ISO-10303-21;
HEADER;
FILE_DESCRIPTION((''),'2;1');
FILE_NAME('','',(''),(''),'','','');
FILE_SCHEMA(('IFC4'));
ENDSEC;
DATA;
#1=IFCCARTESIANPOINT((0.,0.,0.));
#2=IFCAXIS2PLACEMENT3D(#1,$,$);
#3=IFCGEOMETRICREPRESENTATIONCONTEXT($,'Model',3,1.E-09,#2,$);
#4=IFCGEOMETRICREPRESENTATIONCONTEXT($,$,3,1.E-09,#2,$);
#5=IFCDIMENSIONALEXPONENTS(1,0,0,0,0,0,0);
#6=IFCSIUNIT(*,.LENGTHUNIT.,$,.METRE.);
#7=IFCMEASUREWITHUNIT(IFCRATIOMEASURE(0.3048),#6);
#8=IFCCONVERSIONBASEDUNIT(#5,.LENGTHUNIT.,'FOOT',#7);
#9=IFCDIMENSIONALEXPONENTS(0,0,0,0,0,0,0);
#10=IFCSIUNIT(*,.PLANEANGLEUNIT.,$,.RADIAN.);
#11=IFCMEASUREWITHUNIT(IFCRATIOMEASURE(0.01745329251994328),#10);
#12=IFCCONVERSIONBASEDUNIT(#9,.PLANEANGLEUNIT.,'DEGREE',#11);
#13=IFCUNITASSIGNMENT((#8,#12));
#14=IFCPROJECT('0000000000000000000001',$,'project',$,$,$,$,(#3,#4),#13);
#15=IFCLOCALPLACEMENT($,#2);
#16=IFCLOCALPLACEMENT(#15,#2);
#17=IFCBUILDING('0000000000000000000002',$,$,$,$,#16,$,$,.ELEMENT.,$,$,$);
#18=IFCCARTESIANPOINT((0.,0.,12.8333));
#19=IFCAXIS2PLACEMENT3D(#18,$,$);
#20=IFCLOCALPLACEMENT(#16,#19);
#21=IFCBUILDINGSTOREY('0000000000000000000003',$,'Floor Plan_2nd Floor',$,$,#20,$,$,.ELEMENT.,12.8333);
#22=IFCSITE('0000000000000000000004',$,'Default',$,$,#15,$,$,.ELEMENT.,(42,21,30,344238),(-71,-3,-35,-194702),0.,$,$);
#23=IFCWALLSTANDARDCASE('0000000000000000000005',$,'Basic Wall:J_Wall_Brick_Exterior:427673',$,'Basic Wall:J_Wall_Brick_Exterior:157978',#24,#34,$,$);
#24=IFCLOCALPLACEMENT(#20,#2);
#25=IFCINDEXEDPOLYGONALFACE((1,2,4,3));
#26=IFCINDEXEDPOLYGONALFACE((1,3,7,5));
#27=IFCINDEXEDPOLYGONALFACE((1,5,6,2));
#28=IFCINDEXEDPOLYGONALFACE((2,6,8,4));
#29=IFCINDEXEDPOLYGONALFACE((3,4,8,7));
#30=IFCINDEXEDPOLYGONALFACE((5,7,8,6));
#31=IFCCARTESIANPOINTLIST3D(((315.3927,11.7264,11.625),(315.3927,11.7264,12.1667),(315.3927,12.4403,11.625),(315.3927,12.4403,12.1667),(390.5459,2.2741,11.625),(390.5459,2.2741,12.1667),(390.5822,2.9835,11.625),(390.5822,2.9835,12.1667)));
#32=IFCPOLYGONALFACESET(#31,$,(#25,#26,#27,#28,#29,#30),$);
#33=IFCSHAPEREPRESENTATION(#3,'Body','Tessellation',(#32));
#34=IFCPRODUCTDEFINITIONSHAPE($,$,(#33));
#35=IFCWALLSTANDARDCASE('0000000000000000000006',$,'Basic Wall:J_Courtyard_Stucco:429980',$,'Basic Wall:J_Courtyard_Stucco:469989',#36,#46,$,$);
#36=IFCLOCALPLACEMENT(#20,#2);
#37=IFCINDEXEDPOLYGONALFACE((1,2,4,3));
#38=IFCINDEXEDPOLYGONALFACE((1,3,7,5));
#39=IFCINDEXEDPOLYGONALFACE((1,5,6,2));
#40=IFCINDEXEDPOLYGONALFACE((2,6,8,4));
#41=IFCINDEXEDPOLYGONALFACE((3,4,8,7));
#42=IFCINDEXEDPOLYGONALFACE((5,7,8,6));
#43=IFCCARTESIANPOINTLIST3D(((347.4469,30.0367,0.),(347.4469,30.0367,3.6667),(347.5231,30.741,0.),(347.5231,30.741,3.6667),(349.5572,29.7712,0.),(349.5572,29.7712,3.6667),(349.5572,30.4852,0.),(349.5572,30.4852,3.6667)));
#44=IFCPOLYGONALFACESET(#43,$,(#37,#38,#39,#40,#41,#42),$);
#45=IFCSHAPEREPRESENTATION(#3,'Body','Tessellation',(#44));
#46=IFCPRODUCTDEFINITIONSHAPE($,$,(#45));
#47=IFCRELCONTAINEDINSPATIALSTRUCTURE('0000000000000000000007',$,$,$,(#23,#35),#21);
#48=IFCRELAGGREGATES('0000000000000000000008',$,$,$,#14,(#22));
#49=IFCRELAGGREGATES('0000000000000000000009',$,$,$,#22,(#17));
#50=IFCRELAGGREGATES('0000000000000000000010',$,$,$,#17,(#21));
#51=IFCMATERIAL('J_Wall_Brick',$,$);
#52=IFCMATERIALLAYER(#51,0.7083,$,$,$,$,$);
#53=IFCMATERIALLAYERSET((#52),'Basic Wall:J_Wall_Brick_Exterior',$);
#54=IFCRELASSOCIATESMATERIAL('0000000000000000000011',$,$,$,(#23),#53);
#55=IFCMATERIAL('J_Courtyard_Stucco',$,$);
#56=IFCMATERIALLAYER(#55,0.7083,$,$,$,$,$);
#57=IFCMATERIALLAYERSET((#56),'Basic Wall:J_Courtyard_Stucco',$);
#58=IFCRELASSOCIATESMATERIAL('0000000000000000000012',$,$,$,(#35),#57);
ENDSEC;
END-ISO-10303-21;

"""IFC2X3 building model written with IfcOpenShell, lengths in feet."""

from ifc_helpers import new_model, entity, si_unit, converted_unit, frame, origin, place, context, project, spatial, polyline, outline, extrude, clip, halfspace, material, layer, layer_set, layer_usage, element, save


model = new_model("IFC2X3")

# Units and contexts
model_context = context("Model", 3, precision=1e-09, world=origin())
context_of_model = context(None, 3, precision=1e-09, world=origin())
ifc_project = project(units=[converted_unit("LENGTHUNIT", "FOOT", entity("IfcRatioMeasure", 0.3048), si_unit("LENGTHUNIT", "METRE"), dimensions=[1, 0, 0, 0, 0, 0, 0]), converted_unit("PLANEANGLEUNIT", "DEGREE", entity("IfcRatioMeasure", 0.01745329251994328), si_unit("PLANEANGLEUNIT", "RADIAN"), dimensions=[0, 0, 0, 0, 0, 0, 0])], contexts=[model_context, context_of_model])

# Site, building, storey
site_placement = place(None, origin())
site = spatial("IfcSite", under=ifc_project, at=site_placement, Name="Default", CompositionType="ELEMENT", RefLatitude=(42, 21, 30, 344238), RefLongitude=(-71, -3, -35, -194702), RefElevation=0.0)
building_placement = place(site_placement, origin())
building = spatial("IfcBuilding", under=site, at=building_placement, CompositionType="ELEMENT")
storey_placement = place(building_placement, frame((0.0, 0.0, 12.8333)))
storey = spatial("IfcBuildingStorey", under=building, at=storey_placement, Name="Floor Plan_2nd Floor", CompositionType="ELEMENT", Elevation=12.8333)

# Shared definitions
ifc_material_1 = material(Name="J_Wall_Brick")
ifc_layer_1 = layer(ifc_material_1, 0.7083)
ifc_layer_set_1 = layer_set([ifc_layer_1], Name="Basic Wall:J_Wall_Brick_Exterior")

# Walls
ifc_layer_usage_1 = layer_usage(ifc_layer_set_1, "AXIS2", "NEGATIVE", 0.3542)
wall_1_placement = place(storey_placement, frame((315.3485, 12.0889, 11.625), z_axis=(0.0, 0.0, 1.0), x_axis=(0.992183, -0.12479, 0.0)))
element("IfcWallStandardCase", 1, at=wall_1_placement, inside=storey, material=ifc_layer_usage_1, Name="Basic Wall:J_Wall_Brick_Exterior:427673", ObjectType="Basic Wall:J_Wall_Brick_Exterior:157978", context=model_context, shape_type="Clipping", body=[
    clip(extrude(outline(polyline([(75.8344, -0.3542), (75.7819, 0.3542), (74.9463, 0.3542), (0.0, 0.3542), (0.0891, -0.3542), (74.9987, -0.3542), (75.8344, -0.3542)])), origin(), (0.0, 0.0, 1.0), 0.5417), halfspace(origin(), True)),
])
ifc_material_2 = material(Name="J_Courtyard_Stucco")
ifc_layer_2 = layer(ifc_material_2, 0.7083)
ifc_layer_set_2 = layer_set([ifc_layer_2], Name="Basic Wall:J_Courtyard_Stucco")
ifc_layer_usage_2 = layer_usage(ifc_layer_set_2, "AXIS2", "NEGATIVE", 0.3542)
wall_2_placement = place(storey_placement, frame((347.4789, 30.3896, 0.0), z_axis=(0.0, 0.0, 1.0), x_axis=(0.992183, -0.12479, 0.0)))
element("IfcWallStandardCase", 2, at=wall_2_placement, inside=storey, material=ifc_layer_usage_2, Name="Basic Wall:J_Courtyard_Stucco:429980", ObjectType="Basic Wall:J_Courtyard_Stucco:469989", context=model_context, shape_type="Clipping", body=[
    clip(extrude(outline(polyline([(2.1392, -0.3542), (2.0501, 0.3542), (0.0, 0.3542), (0.0123, -0.3542), (2.1392, -0.3542)])), origin(), (0.0, 0.0, 1.0), 3.6667), halfspace(frame((0.0, 0.0, -12.6667)), True)),
])

save(model, "model.ifc")
